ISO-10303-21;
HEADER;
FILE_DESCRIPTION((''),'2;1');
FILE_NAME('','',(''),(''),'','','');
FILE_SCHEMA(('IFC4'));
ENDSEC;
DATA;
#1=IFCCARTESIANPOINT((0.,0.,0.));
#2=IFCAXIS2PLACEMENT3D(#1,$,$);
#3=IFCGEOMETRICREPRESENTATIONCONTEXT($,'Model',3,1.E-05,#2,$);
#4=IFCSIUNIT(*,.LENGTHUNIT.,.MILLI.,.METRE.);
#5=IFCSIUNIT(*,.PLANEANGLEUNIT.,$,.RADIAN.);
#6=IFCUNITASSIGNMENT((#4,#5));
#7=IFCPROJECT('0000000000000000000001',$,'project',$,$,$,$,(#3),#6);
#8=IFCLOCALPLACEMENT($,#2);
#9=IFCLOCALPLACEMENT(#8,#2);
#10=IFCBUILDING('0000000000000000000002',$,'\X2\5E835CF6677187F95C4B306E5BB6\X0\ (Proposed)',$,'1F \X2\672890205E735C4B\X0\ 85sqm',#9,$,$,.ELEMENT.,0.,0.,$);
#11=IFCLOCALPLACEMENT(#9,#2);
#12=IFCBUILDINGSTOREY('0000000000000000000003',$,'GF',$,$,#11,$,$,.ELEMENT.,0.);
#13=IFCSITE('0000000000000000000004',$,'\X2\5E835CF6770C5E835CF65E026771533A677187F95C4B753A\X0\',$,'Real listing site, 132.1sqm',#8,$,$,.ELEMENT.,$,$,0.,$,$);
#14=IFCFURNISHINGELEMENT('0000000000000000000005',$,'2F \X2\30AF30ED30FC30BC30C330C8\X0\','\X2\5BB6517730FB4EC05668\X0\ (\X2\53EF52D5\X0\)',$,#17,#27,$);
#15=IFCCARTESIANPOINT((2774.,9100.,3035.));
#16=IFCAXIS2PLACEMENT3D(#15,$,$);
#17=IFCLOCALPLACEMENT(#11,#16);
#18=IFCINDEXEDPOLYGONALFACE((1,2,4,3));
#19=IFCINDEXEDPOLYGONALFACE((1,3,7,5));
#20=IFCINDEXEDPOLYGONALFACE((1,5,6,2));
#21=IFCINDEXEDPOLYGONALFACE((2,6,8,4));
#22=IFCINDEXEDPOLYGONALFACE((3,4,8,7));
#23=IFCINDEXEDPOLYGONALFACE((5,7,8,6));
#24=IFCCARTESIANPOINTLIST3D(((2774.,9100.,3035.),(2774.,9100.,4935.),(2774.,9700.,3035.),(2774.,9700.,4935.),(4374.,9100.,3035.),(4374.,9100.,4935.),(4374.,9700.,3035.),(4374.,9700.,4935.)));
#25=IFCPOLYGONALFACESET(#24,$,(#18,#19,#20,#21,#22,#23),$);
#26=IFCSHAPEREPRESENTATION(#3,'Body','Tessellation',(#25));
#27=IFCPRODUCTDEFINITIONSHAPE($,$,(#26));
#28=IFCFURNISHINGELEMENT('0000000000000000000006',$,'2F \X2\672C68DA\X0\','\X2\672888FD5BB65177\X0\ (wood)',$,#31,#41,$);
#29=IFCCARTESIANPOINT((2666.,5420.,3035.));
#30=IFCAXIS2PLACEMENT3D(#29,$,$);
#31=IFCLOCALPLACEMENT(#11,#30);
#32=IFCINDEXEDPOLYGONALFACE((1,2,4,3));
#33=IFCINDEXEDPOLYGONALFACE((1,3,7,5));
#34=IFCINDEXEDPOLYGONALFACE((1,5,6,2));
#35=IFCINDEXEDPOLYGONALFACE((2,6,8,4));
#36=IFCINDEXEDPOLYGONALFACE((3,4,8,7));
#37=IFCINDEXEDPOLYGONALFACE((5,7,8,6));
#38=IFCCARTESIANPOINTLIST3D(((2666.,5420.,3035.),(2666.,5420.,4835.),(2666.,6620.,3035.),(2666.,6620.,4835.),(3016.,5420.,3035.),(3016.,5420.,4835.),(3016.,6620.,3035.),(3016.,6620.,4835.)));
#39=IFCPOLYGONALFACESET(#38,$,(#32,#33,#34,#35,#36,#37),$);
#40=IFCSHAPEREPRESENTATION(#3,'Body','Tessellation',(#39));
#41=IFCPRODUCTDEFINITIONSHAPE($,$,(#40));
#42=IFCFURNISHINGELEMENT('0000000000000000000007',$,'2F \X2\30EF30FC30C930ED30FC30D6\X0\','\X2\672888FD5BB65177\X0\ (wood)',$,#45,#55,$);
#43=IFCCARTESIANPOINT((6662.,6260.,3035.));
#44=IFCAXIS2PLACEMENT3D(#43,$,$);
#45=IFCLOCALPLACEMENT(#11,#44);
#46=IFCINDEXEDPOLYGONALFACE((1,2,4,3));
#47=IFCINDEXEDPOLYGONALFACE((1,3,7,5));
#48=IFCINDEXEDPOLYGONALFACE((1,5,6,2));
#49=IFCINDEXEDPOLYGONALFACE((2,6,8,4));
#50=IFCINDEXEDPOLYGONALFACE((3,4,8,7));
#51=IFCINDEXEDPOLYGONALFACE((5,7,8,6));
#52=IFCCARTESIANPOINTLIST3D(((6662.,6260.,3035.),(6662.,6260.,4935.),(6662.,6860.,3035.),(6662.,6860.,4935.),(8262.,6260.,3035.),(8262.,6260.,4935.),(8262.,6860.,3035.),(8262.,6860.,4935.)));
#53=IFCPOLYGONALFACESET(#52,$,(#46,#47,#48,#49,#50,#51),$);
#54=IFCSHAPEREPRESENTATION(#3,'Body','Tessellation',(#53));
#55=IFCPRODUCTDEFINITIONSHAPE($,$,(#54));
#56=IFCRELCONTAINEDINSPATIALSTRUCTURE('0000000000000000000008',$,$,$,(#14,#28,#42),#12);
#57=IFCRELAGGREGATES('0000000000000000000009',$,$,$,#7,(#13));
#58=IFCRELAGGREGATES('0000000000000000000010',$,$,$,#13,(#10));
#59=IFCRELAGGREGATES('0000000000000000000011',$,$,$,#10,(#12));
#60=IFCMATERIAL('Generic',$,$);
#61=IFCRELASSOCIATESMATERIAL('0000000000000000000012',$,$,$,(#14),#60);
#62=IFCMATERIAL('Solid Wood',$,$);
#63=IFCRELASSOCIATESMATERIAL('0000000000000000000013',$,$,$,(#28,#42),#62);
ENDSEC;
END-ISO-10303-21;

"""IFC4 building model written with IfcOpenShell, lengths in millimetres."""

from ifc_helpers import new_model, si_unit, frame, frame_2d, origin, place, context, project, spatial, rectangle, extrude, material, element, save


model = new_model("IFC4")

# Units and contexts
model_context = context("Model", 3, precision=1e-05, world=origin())
ifc_project = project(units=[si_unit("LENGTHUNIT", "METRE", prefix="MILLI"), si_unit("PLANEANGLEUNIT", "RADIAN")], contexts=[model_context])

# Site, building, storey
site_placement = place(None, origin())
site = spatial("IfcSite", under=ifc_project, at=site_placement, Name="広島県広島市東区東蟹屋町", ObjectType="Real listing site, 132.1sqm", CompositionType="ELEMENT", RefElevation=0.0)
building_placement = place(site_placement, origin())
building = spatial("IfcBuilding", under=site, at=building_placement, Name="広島東蟹屋の家 (Proposed)", ObjectType="1F 木造平屋 85sqm", CompositionType="ELEMENT", ElevationOfRefHeight=0.0, ElevationOfTerrain=0.0)
storey_placement = place(building_placement, origin())
storey = spatial("IfcBuildingStorey", under=building, at=storey_placement, Name="GF", CompositionType="ELEMENT", Elevation=0.0)

# Shared definitions
ifc_material_1 = material(Name="Solid Wood")

# Shared definitions
ifc_material_2 = material(Name="Generic")

# Furnishing elements
furnishing_1_placement = place(storey_placement, frame((2774.0, 9100.0, 3035.0)))
element("IfcFurnishingElement", 1, at=furnishing_1_placement, inside=storey, material=ifc_material_2, Name="2F クローゼット", Description="家具・什器 (可動)", context=model_context, shape_type="SweptSolid", body=[
    extrude(rectangle(XDim=1600.0, YDim=600.0, at=frame_2d((800.0, 300.0))), frame((2774.0, 9100.0, 3035.0)), (0.0, 0.0, 1.0), 1900.0),
])
furnishing_2_placement = place(storey_placement, frame((2666.0, 5420.0, 3035.0)))
element("IfcFurnishingElement", 2, at=furnishing_2_placement, inside=storey, material=ifc_material_1, Name="2F 本棚", Description="木製家具 (wood)", context=model_context, shape_type="SweptSolid", body=[
    extrude(rectangle(XDim=350.0, YDim=1200.0, at=frame_2d((175.0, 600.0))), frame((2666.0, 5420.0, 3035.0)), (0.0, 0.0, 1.0), 1800.0),
])
furnishing_3_placement = place(storey_placement, frame((6662.0, 6260.0, 3035.0)))
element("IfcFurnishingElement", 3, at=furnishing_3_placement, inside=storey, material=ifc_material_1, Name="2F ワードローブ", Description="木製家具 (wood)", context=model_context, shape_type="SweptSolid", body=[
    extrude(rectangle(XDim=1600.0, YDim=600.0, at=frame_2d((800.0, 300.0))), frame((6662.0, 6260.0, 3035.0)), (0.0, 0.0, 1.0), 1900.0),
])

save(model, "model.ifc")
